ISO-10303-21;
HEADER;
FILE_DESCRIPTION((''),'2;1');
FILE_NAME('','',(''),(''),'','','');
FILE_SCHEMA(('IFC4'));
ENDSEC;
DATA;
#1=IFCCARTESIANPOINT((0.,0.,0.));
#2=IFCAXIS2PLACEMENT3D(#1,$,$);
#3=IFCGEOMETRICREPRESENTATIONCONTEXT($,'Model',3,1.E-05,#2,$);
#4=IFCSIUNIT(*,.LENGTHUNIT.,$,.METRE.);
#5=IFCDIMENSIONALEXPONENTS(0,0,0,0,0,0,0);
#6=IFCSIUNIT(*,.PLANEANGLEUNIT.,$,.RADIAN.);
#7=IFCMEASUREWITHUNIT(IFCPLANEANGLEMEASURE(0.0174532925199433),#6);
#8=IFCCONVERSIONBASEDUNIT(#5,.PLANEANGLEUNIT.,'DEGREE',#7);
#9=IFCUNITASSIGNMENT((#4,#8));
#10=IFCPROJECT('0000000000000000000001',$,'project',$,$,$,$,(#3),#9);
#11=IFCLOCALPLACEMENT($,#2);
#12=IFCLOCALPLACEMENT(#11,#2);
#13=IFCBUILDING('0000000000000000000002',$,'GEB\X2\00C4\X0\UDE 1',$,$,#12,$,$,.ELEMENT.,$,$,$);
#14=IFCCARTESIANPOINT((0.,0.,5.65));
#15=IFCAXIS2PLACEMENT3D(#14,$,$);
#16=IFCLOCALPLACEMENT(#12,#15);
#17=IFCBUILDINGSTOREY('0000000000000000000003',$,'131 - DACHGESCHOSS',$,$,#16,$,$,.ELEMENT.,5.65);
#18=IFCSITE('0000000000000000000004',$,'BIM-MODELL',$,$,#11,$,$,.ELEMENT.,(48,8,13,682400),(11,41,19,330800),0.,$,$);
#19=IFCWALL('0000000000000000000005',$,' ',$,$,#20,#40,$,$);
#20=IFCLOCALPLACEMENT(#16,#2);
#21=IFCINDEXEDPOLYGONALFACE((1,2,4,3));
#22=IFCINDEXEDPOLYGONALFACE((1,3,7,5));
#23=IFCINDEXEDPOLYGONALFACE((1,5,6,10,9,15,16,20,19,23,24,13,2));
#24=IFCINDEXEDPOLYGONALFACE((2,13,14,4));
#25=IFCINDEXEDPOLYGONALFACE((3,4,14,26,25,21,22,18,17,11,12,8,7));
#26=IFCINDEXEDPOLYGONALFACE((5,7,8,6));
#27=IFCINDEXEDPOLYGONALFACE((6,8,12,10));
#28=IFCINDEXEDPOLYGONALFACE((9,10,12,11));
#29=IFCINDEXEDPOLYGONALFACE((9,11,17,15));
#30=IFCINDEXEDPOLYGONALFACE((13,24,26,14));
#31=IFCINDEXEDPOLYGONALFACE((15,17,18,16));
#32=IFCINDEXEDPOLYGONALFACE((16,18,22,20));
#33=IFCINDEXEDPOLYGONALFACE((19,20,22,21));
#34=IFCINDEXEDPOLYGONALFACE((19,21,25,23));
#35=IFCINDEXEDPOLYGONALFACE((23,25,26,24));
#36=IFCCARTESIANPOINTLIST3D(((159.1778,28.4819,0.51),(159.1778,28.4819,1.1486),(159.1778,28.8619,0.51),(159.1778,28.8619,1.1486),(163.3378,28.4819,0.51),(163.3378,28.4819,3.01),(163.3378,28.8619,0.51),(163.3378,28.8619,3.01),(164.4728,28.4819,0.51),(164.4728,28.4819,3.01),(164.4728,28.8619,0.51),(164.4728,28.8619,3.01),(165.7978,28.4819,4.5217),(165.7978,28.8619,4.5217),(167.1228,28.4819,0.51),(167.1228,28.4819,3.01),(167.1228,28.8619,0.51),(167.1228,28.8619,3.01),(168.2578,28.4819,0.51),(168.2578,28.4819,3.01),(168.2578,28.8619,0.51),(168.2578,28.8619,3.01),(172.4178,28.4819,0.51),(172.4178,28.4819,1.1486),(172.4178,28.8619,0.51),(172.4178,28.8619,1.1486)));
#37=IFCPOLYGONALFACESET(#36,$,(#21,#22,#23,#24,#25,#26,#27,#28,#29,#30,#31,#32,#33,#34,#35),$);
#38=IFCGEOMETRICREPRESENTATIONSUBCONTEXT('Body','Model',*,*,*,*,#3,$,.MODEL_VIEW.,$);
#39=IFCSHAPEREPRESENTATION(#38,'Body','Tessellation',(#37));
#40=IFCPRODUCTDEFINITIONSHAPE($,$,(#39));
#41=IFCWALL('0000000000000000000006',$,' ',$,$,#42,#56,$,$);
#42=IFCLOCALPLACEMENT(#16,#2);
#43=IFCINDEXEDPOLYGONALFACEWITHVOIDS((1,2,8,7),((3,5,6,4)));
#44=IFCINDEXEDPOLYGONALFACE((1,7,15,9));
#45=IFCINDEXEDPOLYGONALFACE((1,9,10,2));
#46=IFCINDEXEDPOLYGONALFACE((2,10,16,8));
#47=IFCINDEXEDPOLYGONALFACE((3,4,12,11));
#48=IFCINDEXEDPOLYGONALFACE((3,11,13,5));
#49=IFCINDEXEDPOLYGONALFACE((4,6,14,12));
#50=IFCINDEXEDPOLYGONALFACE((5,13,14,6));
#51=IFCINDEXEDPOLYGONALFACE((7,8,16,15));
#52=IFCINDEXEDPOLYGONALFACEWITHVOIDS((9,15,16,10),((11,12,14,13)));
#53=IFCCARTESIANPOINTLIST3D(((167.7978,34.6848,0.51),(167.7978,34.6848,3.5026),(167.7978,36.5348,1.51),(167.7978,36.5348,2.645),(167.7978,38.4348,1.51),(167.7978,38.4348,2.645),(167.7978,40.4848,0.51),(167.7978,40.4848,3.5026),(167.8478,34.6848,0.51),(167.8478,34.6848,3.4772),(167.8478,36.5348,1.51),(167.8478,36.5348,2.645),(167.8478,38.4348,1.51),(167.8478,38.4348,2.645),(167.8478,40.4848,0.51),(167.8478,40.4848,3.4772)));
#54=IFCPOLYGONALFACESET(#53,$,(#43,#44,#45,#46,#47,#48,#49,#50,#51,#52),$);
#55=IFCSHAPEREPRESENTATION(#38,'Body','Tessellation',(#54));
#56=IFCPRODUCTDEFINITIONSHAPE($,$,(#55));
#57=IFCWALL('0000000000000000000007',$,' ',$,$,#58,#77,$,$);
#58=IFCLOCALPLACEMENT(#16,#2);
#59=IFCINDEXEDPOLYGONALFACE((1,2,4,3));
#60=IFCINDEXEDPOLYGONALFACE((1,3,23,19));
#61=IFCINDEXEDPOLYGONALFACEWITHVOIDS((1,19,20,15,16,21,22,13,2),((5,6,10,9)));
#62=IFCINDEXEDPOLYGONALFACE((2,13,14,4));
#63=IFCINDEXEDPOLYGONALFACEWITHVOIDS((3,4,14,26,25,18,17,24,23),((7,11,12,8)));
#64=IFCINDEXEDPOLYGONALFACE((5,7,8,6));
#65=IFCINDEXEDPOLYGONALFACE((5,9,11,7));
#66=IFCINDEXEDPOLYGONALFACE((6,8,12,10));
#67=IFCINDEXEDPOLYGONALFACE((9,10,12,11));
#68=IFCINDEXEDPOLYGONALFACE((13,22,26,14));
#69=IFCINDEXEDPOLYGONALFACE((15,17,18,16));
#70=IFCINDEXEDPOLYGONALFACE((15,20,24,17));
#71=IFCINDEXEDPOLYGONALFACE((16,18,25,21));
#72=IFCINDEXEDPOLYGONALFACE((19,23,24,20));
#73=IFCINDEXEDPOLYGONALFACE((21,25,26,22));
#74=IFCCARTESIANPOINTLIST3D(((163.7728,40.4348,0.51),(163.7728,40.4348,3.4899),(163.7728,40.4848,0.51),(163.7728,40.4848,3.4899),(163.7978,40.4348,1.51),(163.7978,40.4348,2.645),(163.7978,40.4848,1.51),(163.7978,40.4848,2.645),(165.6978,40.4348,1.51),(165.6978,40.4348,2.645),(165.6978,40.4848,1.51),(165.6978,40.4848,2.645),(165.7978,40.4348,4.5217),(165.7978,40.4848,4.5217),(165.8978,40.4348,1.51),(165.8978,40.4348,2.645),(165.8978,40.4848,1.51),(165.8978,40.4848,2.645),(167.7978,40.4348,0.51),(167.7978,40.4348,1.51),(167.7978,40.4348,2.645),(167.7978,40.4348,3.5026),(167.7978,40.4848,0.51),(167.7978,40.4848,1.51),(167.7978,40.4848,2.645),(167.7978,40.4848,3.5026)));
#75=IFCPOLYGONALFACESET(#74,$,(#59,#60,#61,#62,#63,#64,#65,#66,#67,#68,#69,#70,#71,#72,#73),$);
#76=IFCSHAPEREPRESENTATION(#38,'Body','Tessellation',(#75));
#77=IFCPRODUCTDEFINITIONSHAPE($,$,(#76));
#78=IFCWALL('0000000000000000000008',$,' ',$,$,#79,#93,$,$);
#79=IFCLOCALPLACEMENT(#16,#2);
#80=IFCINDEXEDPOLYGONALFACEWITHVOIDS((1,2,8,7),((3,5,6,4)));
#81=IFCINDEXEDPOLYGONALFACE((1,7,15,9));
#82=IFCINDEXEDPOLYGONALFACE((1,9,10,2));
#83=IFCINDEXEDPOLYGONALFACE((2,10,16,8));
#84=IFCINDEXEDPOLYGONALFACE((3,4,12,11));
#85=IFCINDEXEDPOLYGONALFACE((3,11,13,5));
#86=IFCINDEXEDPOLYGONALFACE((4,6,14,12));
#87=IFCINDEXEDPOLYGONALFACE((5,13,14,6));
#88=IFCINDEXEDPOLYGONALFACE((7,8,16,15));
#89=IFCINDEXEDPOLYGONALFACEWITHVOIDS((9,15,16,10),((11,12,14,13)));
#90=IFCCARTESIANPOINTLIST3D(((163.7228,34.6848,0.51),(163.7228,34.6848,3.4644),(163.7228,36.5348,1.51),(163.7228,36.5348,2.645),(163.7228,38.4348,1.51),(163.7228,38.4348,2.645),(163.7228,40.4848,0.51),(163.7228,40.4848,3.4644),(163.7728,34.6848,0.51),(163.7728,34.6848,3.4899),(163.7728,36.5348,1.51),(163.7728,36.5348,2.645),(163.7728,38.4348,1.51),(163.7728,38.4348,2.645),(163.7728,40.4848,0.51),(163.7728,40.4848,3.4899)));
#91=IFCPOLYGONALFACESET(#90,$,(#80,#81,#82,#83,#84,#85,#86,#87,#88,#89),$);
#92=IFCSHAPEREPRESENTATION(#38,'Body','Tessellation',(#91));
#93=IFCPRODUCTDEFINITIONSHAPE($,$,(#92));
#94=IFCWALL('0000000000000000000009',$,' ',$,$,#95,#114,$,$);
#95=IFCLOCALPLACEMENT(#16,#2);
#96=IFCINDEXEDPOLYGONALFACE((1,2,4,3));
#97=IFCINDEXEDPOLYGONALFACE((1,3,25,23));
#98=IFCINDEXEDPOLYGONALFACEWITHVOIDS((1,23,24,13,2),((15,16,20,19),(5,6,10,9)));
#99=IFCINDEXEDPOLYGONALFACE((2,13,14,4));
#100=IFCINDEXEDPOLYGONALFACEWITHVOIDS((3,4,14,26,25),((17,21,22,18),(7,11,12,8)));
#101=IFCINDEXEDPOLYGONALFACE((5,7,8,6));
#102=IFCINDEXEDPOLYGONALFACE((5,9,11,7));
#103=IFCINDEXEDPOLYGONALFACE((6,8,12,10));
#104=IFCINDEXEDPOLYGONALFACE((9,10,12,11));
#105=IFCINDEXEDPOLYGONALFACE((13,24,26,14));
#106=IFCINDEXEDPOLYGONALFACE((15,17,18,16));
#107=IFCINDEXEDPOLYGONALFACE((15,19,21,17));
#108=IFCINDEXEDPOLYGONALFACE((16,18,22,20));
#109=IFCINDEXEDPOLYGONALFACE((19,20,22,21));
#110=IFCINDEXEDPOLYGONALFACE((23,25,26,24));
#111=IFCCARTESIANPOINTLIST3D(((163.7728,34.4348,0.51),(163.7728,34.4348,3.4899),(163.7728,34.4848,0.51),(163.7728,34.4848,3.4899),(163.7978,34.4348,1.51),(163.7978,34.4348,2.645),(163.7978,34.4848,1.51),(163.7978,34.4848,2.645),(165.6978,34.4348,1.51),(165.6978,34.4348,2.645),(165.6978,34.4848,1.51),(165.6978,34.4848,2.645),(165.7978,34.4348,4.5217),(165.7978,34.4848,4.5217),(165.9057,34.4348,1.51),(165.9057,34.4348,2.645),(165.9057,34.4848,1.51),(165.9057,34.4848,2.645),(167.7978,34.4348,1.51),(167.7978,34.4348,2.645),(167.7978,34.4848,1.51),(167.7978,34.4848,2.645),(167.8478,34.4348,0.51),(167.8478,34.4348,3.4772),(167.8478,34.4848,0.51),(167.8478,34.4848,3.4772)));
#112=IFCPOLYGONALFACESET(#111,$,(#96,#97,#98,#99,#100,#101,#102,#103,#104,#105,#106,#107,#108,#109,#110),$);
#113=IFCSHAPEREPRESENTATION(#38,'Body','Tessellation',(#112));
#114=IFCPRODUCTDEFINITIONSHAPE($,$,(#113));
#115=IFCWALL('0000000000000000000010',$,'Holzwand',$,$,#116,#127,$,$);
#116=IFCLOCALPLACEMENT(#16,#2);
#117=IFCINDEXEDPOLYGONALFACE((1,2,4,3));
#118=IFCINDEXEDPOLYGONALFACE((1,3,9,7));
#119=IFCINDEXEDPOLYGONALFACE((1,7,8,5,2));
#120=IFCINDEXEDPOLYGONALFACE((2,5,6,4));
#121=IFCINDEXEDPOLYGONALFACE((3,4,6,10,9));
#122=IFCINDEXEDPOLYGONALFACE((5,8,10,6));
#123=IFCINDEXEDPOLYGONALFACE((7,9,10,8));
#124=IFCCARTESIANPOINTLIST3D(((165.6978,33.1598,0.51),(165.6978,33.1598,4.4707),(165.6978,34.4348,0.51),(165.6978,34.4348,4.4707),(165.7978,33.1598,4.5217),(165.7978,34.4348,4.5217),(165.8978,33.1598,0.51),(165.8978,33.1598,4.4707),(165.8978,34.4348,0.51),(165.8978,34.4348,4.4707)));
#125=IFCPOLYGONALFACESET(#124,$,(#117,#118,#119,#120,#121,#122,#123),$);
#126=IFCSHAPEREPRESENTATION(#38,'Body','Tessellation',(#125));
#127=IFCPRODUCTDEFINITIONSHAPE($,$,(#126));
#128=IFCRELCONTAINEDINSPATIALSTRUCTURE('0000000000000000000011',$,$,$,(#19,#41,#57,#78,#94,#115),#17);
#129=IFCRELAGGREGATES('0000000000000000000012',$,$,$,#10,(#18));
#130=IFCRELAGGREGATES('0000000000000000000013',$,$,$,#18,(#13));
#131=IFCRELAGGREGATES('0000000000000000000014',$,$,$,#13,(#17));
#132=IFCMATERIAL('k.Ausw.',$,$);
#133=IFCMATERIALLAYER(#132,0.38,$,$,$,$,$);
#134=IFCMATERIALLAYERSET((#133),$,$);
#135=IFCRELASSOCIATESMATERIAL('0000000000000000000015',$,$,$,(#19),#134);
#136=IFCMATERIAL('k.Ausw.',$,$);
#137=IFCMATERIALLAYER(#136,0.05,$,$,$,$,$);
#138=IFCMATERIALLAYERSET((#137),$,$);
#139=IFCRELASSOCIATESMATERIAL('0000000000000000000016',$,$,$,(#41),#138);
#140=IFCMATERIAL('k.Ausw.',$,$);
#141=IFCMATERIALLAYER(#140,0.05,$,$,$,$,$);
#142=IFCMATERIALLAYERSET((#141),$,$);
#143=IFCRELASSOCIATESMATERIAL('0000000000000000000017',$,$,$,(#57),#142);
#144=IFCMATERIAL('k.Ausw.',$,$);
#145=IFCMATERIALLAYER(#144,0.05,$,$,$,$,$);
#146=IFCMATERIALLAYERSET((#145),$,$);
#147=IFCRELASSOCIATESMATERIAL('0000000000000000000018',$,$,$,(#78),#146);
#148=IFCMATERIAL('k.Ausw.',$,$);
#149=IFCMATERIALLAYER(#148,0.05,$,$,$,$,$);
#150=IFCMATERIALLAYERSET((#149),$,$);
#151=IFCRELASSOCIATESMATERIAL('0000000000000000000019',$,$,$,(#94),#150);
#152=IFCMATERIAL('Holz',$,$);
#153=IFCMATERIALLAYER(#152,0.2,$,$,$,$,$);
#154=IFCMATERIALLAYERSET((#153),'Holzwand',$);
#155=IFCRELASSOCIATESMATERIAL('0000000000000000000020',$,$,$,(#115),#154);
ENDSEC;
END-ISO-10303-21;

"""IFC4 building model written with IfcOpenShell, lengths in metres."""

from ifc_helpers import new_model, entity, si_unit, converted_unit, frame, frame_2d, origin, origin_with_axes, place, context, subcontext, project, spatial, polyline, rectangle, outline, extrude, clip, halfspace, bounded_halfspace, material, layer, layer_set, layer_usage, element, save


model = new_model("IFC4")

# Units and contexts
model_context = context("Model", 3, precision=1e-05, world=origin())
body_context = subcontext(model_context, "Body", "Model", "MODEL_VIEW")
ifc_project = project(units=[si_unit("LENGTHUNIT", "METRE"), converted_unit("PLANEANGLEUNIT", "DEGREE", entity("IfcPlaneAngleMeasure", 0.0174532925199433), si_unit("PLANEANGLEUNIT", "RADIAN"), dimensions=[0, 0, 0, 0, 0, 0, 0])], contexts=[model_context])

# Site, building, storey
site_placement = place(None, origin())
site = spatial("IfcSite", under=ifc_project, at=site_placement, Name="BIM-MODELL", CompositionType="ELEMENT", RefLatitude=(48, 8, 13, 682400), RefLongitude=(11, 41, 19, 330800), RefElevation=0.0)
building_placement = place(site_placement, origin())
building = spatial("IfcBuilding", under=site, at=building_placement, Name="GEBÄUDE 1", CompositionType="ELEMENT")
storey_placement = place(building_placement, frame((0.0, 0.0, 5.65)))
storey = spatial("IfcBuildingStorey", under=building, at=storey_placement, Name="131 - DACHGESCHOSS", CompositionType="ELEMENT", Elevation=5.65)

# Wall, openings
ifc_material_1 = material(Name="k.Ausw.")
ifc_layer_1 = layer(ifc_material_1, 0.38)
ifc_layer_set_1 = layer_set([ifc_layer_1])
ifc_layer_usage_1 = layer_usage(ifc_layer_set_1, "AXIS2", "POSITIVE", 0.0)
wall_1_placement = place(storey_placement, frame((159.1778, 28.4819, 0.51), z_axis=(0.0, 0.0, 1.0), x_axis=(1.0, 0.0, 0.0)))
wall_1 = element("IfcWall", 1, at=wall_1_placement, inside=storey, material=ifc_layer_usage_1, Name=" ", context=body_context, shape_type="Clipping", body=[
    clip(clip(extrude(rectangle(XDim=13.24, YDim=0.38, at=frame_2d((6.62, 0.19), x_axis=(1.0, 0.0))), origin_with_axes(), (0.0, 0.0, 1.0), 4.0117), bounded_halfspace(frame((3.31, 0.19, 2.3251), z_axis=(0.45399, 0.0, -0.891007), x_axis=(0.0, -1.0, 0.0)), True, origin_with_axes(), polyline([(0.0, 0.38), (0.0, 0.0), (6.62, 0.0), (6.62, 0.38), (0.0, 0.38)]))), bounded_halfspace(frame((9.93, 0.19, 2.3251), z_axis=(-0.45399, 0.0, -0.891007), x_axis=(0.891007, 0.0, -0.45399)), True, origin_with_axes(), polyline([(6.62, 0.0), (13.24, 0.0), (13.24, 0.38), (6.62, 0.38), (6.62, 0.0)]))),
])
opening_1_placement = place(wall_1_placement, frame((5.295, 0.38, 0.0), z_axis=(0.0, -1.0, 0.0), x_axis=(0.0, 0.0, 1.0)))
element("IfcOpeningElement", 2, at=opening_1_placement, cuts=wall_1, ObjectType="Opening", context=body_context, shape_type="SweptSolid", body=[
    extrude(outline(polyline([(0.0, 1.135), (2.5, 1.135), (2.5, 0.0), (0.0, 0.0), (0.0, 1.135)])), origin_with_axes(), (0.0, 0.0, 1.0), 0.38),
])
opening_2_placement = place(wall_1_placement, frame((9.08, 0.38, 0.0), z_axis=(0.0, -1.0, 0.0), x_axis=(0.0, 0.0, 1.0)))
element("IfcOpeningElement", 3, at=opening_2_placement, cuts=wall_1, ObjectType="Opening", context=body_context, shape_type="SweptSolid", body=[
    extrude(outline(polyline([(0.0, 1.135), (2.5, 1.135), (2.5, 0.0), (0.0, 0.0), (0.0, 1.135)])), origin_with_axes(), (0.0, 0.0, 1.0), 0.38),
])

# Wall, opening
ifc_material_2 = material(Name="k.Ausw.")
ifc_layer_2 = layer(ifc_material_2, 0.05)
ifc_layer_set_2 = layer_set([ifc_layer_2])
ifc_layer_usage_2 = layer_usage(ifc_layer_set_2, "AXIS2", "POSITIVE", 0.0)
wall_2_placement = place(storey_placement, frame((167.8478, 34.6848, 0.51), z_axis=(0.0, 0.0, 1.0), x_axis=(0.0, 1.0, 0.0)))
wall_2 = element("IfcWall", 4, at=wall_2_placement, inside=storey, material=ifc_layer_usage_2, Name=" ", context=body_context, shape_type="Clipping", body=[
    clip(extrude(rectangle(XDim=5.8, YDim=0.05, at=frame_2d((2.9, 0.025), x_axis=(1.0, 0.0))), origin_with_axes(), (0.0, 0.0, 1.0), 2.9926), halfspace(frame((2.9, 0.025, 2.9799), z_axis=(0.0, 0.45399, -0.891007), x_axis=(1.0, 0.0, 0.0)), True)),
])
opening_3_placement = place(wall_2_placement, frame((1.85, 0.0, 1.0), z_axis=(0.0, 1.0, 0.0), x_axis=(0.0, 0.0, 1.0)))
element("IfcOpeningElement", 5, at=opening_3_placement, cuts=wall_2, ObjectType="Opening", context=body_context, shape_type="SweptSolid", body=[
    extrude(outline(polyline([(0.0, 1.9), (1.135, 1.9), (1.135, 0.0), (0.0, 0.0), (0.0, 1.9)])), origin_with_axes(), (0.0, 0.0, 1.0), 0.05),
])

# Wall, openings
ifc_material_3 = material(Name="k.Ausw.")
ifc_layer_3 = layer(ifc_material_3, 0.05)
ifc_layer_set_3 = layer_set([ifc_layer_3])
ifc_layer_usage_3 = layer_usage(ifc_layer_set_3, "AXIS2", "POSITIVE", 0.0)
wall_3_placement = place(storey_placement, frame((167.7978, 40.4848, 0.51), z_axis=(0.0, 0.0, 1.0), x_axis=(-1.0, 0.0, 0.0)))
wall_3 = element("IfcWall", 6, at=wall_3_placement, inside=storey, material=ifc_layer_usage_3, Name=" ", context=body_context, shape_type="Clipping", body=[
    clip(clip(extrude(rectangle(XDim=4.025, YDim=0.05, at=frame_2d((2.0125, 0.025), x_axis=(1.0, 0.0))), origin_with_axes(), (0.0, 0.0, 1.0), 4.0117), bounded_halfspace(frame((3.0125, 0.025, 3.4958), z_axis=(-0.45399, 0.0, -0.891007), x_axis=(-0.891007, 0.0, 0.45399)), True, origin_with_axes(), polyline([(4.025, 0.05), (2.0, 0.05), (2.0, 0.0), (4.025, 0.0), (4.025, 0.05)]))), bounded_halfspace(frame((1.0, 0.025, 3.5022), z_axis=(0.45399, 0.0, -0.891007), x_axis=(0.891007, 0.0, 0.45399)), True, origin_with_axes(), polyline([(0.0, 0.0), (2.0, 0.0), (2.0, 0.05), (0.0, 0.05), (0.0, 0.0)]))),
])
opening_4_placement = place(wall_3_placement, frame((0.0, 0.0, 1.0), z_axis=(0.0, 1.0, 0.0), x_axis=(0.0, 0.0, 1.0)))
element("IfcOpeningElement", 7, at=opening_4_placement, cuts=wall_3, ObjectType="Opening", context=body_context, shape_type="SweptSolid", body=[
    extrude(outline(polyline([(0.0, 1.9), (1.135, 1.9), (1.135, 0.0), (0.0, 0.0), (0.0, 1.9)])), origin_with_axes(), (0.0, 0.0, 1.0), 0.05),
])
opening_5_placement = place(wall_3_placement, frame((2.1, 0.0, 1.0), z_axis=(0.0, 1.0, 0.0), x_axis=(0.0, 0.0, 1.0)))
element("IfcOpeningElement", 8, at=opening_5_placement, cuts=wall_3, ObjectType="Opening", context=body_context, shape_type="SweptSolid", body=[
    extrude(outline(polyline([(0.0, 1.9), (1.135, 1.9), (1.135, 0.0), (0.0, 0.0), (0.0, 1.9)])), origin_with_axes(), (0.0, 0.0, 1.0), 0.05),
])

# Wall, opening
ifc_material_4 = material(Name="k.Ausw.")
ifc_layer_4 = layer(ifc_material_4, 0.05)
ifc_layer_set_4 = layer_set([ifc_layer_4])
ifc_layer_usage_4 = layer_usage(ifc_layer_set_4, "AXIS2", "POSITIVE", 0.0)
wall_4_placement = place(storey_placement, frame((163.7228, 40.4848, 0.51), z_axis=(0.0, 0.0, 1.0), x_axis=(0.0, -1.0, 0.0)))
wall_4 = element("IfcWall", 9, at=wall_4_placement, inside=storey, material=ifc_layer_usage_4, Name=" ", context=body_context, shape_type="Clipping", body=[
    clip(extrude(rectangle(XDim=5.8, YDim=0.05, at=frame_2d((2.9, 0.025), x_axis=(1.0, 0.0))), origin_with_axes(), (0.0, 0.0, 1.0), 2.9799), halfspace(frame((2.9, 0.025, 2.9672), z_axis=(0.0, 0.45399, -0.891007), x_axis=(1.0, 0.0, 0.0)), True)),
])
opening_6_placement = place(wall_4_placement, frame((2.05, 0.0, 1.0), z_axis=(0.0, 1.0, 0.0), x_axis=(0.0, 0.0, 1.0)))
element("IfcOpeningElement", 10, at=opening_6_placement, cuts=wall_4, ObjectType="Opening", context=body_context, shape_type="SweptSolid", body=[
    extrude(outline(polyline([(0.0, 1.9), (1.135, 1.9), (1.135, 0.0), (0.0, 0.0), (0.0, 1.9)])), origin_with_axes(), (0.0, 0.0, 1.0), 0.05),
])

# Wall, openings
ifc_material_5 = material(Name="k.Ausw.")
ifc_layer_5 = layer(ifc_material_5, 0.05)
ifc_layer_set_5 = layer_set([ifc_layer_5])
ifc_layer_usage_5 = layer_usage(ifc_layer_set_5, "AXIS2", "POSITIVE", 0.0)
wall_5_placement = place(storey_placement, frame((163.7728, 34.4348, 0.51), z_axis=(0.0, 0.0, 1.0), x_axis=(1.0, 0.0, 0.0)))
wall_5 = element("IfcWall", 11, at=wall_5_placement, inside=storey, material=ifc_layer_usage_5, Name=" ", context=body_context, shape_type="Clipping", body=[
    clip(clip(extrude(rectangle(XDim=4.075, YDim=0.05, at=frame_2d((2.0375, 0.025), x_axis=(1.0, 0.0))), origin_with_axes(), (0.0, 0.0, 1.0), 4.0117), bounded_halfspace(frame((1.0125, 0.025, 3.4958), z_axis=(0.45399, 0.0, -0.891007), x_axis=(0.891007, 0.0, 0.45399)), True, origin_with_axes(), polyline([(0.0, 0.0), (2.025, 0.0), (2.025, 0.05), (0.0, 0.05), (0.0, 0.0)]))), bounded_halfspace(frame((3.05, 0.025, 3.4894), z_axis=(-0.45399, 0.0, -0.891007), x_axis=(-0.891007, 0.0, 0.45399)), True, origin_with_axes(), polyline([(4.075, 0.05), (2.025, 0.05), (2.025, 0.0), (4.075, 0.0), (4.075, 0.05)]))),
])
opening_7_placement = place(wall_5_placement, frame((2.133, 0.0, 1.0), z_axis=(0.0, 1.0, 0.0), x_axis=(0.0, 0.0, 1.0)))
element("IfcOpeningElement", 12, at=opening_7_placement, cuts=wall_5, ObjectType="Opening", context=body_context, shape_type="SweptSolid", body=[
    extrude(outline(polyline([(0.0, 1.892), (1.135, 1.892), (1.135, 0.0), (0.0, 0.0), (0.0, 1.892)])), origin_with_axes(), (0.0, 0.0, 1.0), 0.05),
])
opening_8_placement = place(wall_5_placement, frame((0.025, 0.0, 1.0), z_axis=(0.0, 1.0, 0.0), x_axis=(0.0, 0.0, 1.0)))
element("IfcOpeningElement", 13, at=opening_8_placement, cuts=wall_5, ObjectType="Opening", context=body_context, shape_type="SweptSolid", body=[
    extrude(outline(polyline([(0.0, 1.9), (1.135, 1.9), (1.135, 0.0), (0.0, 0.0), (0.0, 1.9)])), origin_with_axes(), (0.0, 0.0, 1.0), 0.05),
])

# Wall
ifc_material_6 = material(Name="Holz")
ifc_layer_6 = layer(ifc_material_6, 0.2)
ifc_layer_set_6 = layer_set([ifc_layer_6], Name="Holzwand")
ifc_layer_usage_6 = layer_usage(ifc_layer_set_6, "AXIS2", "POSITIVE", 0.0)
wall_6_placement = place(storey_placement, frame((165.6978, 34.4348, 0.51), z_axis=(0.0, 0.0, 1.0), x_axis=(0.0, -1.0, 0.0)))
element("IfcWall", 14, at=wall_6_placement, inside=storey, material=ifc_layer_usage_6, Name="Holzwand", context=body_context, shape_type="Clipping", body=[
    clip(clip(extrude(rectangle(XDim=1.275, YDim=0.2, at=frame_2d((0.6375, 0.1), x_axis=(1.0, 0.0))), origin_with_axes(), (0.0, 0.0, 1.0), 4.0117), bounded_halfspace(frame((0.6375, 0.05, 3.9862), z_axis=(0.0, 0.45399, -0.891007), x_axis=(0.0, 0.891007, 0.45399)), True, origin_with_axes(), polyline([(1.275, 0.0), (1.275, 0.1), (0.0, 0.1), (0.0, 0.0), (1.275, 0.0)]))), bounded_halfspace(frame((0.6375, 0.15, 3.9862), z_axis=(0.0, -0.45399, -0.891007), x_axis=(0.0, -0.891007, 0.45399)), True, origin_with_axes(), polyline([(0.0, 0.2), (0.0, 0.1), (1.275, 0.1), (1.275, 0.2), (0.0, 0.2)]))),
])

save(model, "model.ifc")
